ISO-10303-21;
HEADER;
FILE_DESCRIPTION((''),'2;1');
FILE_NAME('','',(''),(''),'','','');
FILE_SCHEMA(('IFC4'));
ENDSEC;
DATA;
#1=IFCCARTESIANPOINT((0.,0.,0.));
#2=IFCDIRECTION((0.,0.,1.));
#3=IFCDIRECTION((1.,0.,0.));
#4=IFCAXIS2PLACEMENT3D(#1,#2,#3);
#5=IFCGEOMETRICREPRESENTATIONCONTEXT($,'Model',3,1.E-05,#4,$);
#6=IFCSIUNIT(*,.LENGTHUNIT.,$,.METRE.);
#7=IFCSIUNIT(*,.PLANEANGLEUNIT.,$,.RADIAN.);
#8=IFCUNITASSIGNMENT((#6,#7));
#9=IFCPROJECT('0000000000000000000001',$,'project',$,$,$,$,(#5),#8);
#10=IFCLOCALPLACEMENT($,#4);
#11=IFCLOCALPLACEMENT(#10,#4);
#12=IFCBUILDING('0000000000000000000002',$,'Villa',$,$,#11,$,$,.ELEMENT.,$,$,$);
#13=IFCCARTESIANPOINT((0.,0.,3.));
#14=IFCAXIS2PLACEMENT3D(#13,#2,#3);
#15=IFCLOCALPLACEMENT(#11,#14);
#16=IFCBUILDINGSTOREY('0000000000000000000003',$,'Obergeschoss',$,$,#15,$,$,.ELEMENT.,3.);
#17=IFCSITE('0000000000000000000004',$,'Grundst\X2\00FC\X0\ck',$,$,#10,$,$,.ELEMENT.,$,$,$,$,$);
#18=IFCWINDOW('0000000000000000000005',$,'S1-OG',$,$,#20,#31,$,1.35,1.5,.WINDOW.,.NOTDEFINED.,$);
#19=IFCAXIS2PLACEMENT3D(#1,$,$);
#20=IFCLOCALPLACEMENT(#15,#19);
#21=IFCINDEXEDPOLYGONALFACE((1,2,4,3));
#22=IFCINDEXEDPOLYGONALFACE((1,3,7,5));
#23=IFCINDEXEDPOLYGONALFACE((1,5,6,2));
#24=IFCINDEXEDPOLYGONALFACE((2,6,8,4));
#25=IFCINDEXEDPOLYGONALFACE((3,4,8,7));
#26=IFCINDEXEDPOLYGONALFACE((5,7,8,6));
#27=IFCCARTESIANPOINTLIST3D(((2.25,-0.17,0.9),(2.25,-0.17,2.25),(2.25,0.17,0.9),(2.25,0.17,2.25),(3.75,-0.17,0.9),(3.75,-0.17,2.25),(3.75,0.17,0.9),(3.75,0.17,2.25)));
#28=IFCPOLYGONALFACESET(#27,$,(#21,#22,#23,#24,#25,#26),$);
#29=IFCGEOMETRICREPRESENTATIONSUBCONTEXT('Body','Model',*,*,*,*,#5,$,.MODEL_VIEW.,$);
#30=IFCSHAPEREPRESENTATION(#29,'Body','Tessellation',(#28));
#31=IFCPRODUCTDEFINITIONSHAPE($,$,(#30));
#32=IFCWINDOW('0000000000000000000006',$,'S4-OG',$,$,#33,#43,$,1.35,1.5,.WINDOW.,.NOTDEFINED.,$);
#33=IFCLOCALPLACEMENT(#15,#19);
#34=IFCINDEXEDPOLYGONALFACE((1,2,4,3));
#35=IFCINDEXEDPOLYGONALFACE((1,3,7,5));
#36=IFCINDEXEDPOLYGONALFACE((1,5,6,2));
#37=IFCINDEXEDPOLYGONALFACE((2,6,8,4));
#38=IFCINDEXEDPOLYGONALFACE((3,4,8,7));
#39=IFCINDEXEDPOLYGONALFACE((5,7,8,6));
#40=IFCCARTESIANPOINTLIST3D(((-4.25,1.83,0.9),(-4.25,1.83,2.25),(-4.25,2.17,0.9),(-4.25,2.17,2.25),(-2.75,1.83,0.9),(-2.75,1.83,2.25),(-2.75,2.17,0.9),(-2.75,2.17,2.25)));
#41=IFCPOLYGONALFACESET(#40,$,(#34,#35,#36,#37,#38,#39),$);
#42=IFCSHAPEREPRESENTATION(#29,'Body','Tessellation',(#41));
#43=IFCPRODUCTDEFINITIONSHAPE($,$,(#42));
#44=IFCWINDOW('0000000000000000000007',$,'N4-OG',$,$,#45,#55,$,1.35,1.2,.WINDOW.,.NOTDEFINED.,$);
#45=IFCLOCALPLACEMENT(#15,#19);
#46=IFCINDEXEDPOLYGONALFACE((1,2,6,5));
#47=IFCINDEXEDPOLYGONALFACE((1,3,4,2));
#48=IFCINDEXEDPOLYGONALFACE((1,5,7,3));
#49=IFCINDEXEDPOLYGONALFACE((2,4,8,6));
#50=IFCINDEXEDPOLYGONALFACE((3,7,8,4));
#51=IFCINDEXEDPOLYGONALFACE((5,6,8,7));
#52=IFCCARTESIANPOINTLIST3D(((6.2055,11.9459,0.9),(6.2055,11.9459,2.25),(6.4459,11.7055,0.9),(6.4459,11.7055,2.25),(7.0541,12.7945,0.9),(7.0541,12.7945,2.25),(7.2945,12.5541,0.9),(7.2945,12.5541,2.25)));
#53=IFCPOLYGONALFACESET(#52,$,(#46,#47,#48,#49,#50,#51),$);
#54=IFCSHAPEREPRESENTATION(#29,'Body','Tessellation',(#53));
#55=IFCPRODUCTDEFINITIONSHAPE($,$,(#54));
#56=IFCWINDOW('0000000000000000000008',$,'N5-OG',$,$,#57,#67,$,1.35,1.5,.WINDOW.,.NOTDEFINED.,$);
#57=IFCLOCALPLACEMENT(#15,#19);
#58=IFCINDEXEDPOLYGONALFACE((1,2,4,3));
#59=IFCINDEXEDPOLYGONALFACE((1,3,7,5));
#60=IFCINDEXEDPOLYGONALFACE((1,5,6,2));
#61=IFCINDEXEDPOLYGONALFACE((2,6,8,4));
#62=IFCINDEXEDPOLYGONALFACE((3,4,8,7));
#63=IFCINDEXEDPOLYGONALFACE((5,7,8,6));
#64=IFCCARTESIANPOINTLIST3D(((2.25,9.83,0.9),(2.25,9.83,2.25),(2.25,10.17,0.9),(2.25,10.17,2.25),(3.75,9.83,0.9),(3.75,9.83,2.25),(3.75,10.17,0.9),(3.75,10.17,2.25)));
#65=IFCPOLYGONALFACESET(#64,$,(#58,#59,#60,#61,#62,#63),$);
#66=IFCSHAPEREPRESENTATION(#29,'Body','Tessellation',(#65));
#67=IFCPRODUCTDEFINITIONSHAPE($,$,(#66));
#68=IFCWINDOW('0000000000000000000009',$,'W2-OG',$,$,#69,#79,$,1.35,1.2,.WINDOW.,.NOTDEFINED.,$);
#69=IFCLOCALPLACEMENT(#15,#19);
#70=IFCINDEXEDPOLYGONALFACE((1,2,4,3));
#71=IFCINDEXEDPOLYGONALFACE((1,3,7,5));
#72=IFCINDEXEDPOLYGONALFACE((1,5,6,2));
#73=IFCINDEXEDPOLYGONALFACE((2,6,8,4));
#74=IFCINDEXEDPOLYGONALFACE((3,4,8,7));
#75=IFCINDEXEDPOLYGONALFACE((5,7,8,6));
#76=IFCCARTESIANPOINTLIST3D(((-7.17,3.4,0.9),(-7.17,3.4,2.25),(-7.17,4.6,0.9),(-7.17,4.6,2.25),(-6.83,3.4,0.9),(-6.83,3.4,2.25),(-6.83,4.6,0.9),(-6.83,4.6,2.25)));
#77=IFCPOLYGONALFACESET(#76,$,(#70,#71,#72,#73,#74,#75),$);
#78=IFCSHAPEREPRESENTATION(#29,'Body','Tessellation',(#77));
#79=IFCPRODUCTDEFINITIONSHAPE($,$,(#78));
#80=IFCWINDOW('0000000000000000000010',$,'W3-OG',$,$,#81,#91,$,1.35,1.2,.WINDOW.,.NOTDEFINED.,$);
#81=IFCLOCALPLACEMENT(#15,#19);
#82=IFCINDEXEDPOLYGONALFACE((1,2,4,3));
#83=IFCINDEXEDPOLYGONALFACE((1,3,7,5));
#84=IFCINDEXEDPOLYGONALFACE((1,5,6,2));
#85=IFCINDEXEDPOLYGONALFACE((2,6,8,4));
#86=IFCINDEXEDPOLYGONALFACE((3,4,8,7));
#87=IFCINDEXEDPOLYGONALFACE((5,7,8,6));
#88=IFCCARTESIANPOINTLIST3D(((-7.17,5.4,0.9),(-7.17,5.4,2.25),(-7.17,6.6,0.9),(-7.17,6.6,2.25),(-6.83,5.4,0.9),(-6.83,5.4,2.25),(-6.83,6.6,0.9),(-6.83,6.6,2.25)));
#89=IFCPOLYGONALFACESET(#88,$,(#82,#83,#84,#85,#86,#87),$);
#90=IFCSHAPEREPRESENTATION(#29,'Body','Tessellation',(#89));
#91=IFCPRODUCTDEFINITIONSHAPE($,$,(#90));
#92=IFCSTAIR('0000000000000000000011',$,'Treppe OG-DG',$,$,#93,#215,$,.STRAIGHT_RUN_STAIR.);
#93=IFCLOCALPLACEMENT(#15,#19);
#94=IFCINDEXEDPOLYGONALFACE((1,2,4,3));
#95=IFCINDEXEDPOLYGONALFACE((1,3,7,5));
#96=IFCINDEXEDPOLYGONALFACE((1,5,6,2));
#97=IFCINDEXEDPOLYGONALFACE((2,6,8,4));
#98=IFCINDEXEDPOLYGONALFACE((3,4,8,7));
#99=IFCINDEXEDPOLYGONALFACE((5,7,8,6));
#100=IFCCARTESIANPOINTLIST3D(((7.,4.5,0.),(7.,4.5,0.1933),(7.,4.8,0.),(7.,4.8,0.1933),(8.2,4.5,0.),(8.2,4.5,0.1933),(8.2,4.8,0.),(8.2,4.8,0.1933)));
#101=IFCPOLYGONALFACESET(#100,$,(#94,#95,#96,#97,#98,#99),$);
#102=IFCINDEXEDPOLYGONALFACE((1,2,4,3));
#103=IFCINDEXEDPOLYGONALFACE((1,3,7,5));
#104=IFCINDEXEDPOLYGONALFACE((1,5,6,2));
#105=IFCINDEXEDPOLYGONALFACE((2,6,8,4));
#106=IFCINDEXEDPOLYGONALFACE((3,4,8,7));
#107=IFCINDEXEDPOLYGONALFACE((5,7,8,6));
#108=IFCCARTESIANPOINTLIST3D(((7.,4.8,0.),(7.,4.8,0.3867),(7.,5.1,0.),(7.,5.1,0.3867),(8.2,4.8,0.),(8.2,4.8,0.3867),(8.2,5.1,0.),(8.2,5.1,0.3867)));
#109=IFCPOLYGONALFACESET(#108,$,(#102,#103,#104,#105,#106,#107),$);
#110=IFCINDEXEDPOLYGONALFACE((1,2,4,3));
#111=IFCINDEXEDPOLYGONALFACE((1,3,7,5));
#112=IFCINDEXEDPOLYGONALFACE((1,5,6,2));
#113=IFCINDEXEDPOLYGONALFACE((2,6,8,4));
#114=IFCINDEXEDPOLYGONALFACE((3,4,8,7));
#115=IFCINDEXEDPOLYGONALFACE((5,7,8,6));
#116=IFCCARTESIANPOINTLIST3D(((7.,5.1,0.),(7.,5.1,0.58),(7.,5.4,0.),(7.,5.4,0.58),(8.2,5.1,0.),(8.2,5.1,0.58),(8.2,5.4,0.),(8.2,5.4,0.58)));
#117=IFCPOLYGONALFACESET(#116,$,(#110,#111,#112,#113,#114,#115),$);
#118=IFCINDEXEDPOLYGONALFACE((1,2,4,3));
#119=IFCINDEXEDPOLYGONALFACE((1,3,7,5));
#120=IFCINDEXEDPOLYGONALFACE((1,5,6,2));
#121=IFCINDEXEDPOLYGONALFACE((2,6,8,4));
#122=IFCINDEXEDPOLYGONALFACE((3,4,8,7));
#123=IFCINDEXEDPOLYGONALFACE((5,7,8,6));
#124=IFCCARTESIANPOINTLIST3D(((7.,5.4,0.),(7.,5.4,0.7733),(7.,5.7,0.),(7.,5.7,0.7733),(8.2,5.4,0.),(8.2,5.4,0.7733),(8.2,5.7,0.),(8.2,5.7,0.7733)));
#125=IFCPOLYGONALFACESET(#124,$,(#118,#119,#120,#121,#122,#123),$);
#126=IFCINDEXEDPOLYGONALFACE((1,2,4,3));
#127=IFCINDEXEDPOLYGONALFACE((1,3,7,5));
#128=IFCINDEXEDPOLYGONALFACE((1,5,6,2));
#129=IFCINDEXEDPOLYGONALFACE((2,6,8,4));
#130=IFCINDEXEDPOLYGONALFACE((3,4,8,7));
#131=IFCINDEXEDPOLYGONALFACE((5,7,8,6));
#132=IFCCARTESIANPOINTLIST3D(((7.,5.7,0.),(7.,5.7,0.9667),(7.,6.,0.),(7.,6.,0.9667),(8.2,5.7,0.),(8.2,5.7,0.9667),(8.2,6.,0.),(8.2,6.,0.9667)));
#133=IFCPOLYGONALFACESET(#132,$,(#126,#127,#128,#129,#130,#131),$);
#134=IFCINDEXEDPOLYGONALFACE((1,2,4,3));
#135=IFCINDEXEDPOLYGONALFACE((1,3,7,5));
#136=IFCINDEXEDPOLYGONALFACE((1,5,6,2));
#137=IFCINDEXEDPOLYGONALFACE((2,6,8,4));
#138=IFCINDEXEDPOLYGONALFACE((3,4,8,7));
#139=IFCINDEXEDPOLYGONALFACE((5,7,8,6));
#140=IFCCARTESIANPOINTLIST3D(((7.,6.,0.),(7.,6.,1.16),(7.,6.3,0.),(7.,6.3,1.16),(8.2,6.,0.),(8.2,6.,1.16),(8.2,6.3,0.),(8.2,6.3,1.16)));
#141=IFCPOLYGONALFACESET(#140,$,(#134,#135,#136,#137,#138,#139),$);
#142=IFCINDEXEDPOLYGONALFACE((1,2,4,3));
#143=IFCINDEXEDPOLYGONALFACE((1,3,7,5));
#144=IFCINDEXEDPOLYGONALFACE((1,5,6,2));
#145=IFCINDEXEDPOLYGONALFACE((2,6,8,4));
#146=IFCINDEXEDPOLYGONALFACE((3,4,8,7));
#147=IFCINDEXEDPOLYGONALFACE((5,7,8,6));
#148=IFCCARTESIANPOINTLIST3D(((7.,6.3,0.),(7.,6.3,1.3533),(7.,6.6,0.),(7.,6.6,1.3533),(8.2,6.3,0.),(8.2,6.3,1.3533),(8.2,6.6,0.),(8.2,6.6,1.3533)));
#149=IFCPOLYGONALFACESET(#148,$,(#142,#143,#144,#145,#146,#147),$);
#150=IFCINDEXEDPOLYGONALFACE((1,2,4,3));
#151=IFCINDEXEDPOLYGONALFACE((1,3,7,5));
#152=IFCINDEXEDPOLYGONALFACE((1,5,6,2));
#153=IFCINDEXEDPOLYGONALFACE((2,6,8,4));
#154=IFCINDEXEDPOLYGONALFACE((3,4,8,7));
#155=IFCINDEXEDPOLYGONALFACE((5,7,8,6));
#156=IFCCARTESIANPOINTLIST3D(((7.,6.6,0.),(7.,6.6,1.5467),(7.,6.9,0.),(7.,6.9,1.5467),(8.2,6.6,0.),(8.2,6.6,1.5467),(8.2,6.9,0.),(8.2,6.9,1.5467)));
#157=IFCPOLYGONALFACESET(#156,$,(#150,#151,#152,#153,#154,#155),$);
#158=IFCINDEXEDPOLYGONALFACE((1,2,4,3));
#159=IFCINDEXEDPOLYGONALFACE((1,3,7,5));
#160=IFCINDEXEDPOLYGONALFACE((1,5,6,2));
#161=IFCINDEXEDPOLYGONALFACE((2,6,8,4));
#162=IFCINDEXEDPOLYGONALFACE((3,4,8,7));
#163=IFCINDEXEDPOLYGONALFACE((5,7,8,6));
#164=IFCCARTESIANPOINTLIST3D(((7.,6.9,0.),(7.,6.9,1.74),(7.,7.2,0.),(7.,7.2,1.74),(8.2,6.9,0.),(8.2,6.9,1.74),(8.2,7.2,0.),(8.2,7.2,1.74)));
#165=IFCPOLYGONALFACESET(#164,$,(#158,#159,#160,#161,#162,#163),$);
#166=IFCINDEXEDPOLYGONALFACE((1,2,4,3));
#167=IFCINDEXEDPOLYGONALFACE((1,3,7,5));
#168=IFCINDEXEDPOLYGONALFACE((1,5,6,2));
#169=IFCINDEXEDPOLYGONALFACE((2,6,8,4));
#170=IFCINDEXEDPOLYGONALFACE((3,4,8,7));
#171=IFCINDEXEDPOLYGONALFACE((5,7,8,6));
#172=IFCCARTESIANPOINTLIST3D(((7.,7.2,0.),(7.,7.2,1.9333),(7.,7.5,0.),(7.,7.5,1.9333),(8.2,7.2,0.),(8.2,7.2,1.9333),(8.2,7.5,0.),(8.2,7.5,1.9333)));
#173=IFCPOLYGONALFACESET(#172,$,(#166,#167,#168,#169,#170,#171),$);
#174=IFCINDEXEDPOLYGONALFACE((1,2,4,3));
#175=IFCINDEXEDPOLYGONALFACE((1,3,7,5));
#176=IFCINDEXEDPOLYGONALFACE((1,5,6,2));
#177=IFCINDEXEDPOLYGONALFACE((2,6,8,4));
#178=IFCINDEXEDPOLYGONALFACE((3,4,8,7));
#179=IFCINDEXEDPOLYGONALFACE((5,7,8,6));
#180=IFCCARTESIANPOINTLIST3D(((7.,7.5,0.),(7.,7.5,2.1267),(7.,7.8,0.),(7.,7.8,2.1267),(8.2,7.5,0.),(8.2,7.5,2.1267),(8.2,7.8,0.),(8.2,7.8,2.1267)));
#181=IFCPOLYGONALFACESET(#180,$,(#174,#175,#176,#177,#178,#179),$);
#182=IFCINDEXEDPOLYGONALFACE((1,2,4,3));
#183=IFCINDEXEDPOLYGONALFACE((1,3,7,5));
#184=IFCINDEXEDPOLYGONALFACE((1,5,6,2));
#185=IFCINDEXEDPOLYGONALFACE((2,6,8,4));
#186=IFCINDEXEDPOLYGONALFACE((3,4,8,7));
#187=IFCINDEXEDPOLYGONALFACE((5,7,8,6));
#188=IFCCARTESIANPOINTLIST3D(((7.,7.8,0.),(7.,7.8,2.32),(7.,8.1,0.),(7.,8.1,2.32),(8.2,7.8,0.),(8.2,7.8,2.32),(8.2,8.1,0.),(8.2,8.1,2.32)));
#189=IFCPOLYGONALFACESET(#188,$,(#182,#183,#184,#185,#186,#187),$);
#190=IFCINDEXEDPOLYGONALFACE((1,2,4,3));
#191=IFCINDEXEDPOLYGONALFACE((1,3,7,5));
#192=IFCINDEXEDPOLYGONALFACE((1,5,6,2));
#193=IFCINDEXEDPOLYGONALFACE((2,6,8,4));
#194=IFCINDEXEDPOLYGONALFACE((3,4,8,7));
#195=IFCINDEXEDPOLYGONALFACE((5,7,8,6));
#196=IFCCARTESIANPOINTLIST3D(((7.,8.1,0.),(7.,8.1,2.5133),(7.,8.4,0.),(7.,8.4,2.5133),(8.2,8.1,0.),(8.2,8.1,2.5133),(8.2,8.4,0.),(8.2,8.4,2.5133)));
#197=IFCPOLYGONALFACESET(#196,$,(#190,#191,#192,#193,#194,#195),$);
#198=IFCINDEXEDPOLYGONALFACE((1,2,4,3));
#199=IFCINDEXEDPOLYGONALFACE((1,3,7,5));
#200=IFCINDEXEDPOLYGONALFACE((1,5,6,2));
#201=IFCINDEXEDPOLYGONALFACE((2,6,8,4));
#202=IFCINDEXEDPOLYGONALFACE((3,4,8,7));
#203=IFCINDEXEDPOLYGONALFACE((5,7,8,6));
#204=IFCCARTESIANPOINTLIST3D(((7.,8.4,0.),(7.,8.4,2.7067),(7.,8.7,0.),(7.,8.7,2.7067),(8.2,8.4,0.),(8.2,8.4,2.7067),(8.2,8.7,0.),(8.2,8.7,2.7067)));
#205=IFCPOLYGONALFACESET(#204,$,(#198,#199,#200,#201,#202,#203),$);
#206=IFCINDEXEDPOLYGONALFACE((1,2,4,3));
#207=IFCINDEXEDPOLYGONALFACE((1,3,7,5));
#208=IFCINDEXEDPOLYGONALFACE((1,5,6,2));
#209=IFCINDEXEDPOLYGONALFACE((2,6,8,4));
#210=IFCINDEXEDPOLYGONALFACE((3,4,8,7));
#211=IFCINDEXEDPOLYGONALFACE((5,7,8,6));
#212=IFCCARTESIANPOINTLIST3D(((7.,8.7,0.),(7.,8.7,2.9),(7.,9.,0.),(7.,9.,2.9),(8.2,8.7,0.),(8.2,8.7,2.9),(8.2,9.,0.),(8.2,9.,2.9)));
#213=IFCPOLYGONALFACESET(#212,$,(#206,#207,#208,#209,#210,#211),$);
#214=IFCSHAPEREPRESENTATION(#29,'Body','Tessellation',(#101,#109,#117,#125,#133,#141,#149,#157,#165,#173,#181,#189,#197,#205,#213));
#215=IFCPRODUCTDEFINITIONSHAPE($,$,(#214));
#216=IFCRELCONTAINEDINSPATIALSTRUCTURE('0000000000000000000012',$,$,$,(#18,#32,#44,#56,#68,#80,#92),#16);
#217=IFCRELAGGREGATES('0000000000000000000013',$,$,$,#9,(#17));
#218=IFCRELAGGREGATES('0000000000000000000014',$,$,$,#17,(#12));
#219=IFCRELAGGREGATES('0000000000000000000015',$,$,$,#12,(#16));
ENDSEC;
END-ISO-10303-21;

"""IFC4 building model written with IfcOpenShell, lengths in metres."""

from ifc_helpers import new_model, si_unit, frame, frame_2d, origin_with_axes, origin_2d, place, context, subcontext, project, spatial, rectangle, extrude, element, save


model = new_model("IFC4")

# Units and contexts
model_context = context("Model", 3, precision=1e-05, world=origin_with_axes())
body_context = subcontext(model_context, "Body", "Model", "MODEL_VIEW")
ifc_project = project(units=[si_unit("LENGTHUNIT", "METRE"), si_unit("PLANEANGLEUNIT", "RADIAN")], contexts=[model_context])

# Site, building, storey
site_placement = place(None, origin_with_axes())
site = spatial("IfcSite", under=ifc_project, at=site_placement, Name="Grundstück", CompositionType="ELEMENT")
building_placement = place(site_placement, origin_with_axes())
building = spatial("IfcBuilding", under=site, at=building_placement, Name="Villa", CompositionType="ELEMENT")
storey_placement = place(building_placement, frame((0.0, 0.0, 3.0), z_axis=(0.0, 0.0, 1.0), x_axis=(1.0, 0.0, 0.0)))
storey = spatial("IfcBuildingStorey", under=building, at=storey_placement, Name="Obergeschoss", CompositionType="ELEMENT", Elevation=3.0)

# Windows
for number, where, z_axis, x_axis, name in (
    (1, (3.0, 0.0, 0.9), (0.0, 0.0, 1.0), (1.0, 0.0, 0.0), "S1-OG"),
    (2, (-3.5, 2.0, 0.9), (0.0, 0.0, 1.0), (1.0, 0.0, 0.0), "S4-OG"),
):
    element("IfcWindow", number, at=place(storey_placement, frame(where, z_axis=z_axis, x_axis=x_axis)), inside=storey, Name=name, OverallHeight=1.35, OverallWidth=1.5, PartitioningType="NOTDEFINED", PredefinedType="WINDOW", context=body_context, shape_type="SweptSolid", body=[
        extrude(rectangle(XDim=1.5, YDim=0.34, at=origin_2d()), origin_with_axes(), (0.0, 0.0, 1.0), 1.35),
    ])
window_1_placement = place(storey_placement, frame((6.75, 12.25, 0.9), z_axis=(0.0, 0.0, 1.0), x_axis=(-0.7071, -0.7071, 0.0)))
element("IfcWindow", 3, at=window_1_placement, inside=storey, Name="N4-OG", OverallHeight=1.35, OverallWidth=1.2, PartitioningType="NOTDEFINED", PredefinedType="WINDOW", context=body_context, shape_type="SweptSolid", body=[
    extrude(rectangle(XDim=1.2, YDim=0.34, at=origin_2d()), origin_with_axes(), (0.0, 0.0, 1.0), 1.35),
])
window_2_placement = place(storey_placement, frame((3.0, 10.0, 0.9), z_axis=(0.0, 0.0, 1.0), x_axis=(1.0, 0.0, 0.0)))
element("IfcWindow", 4, at=window_2_placement, inside=storey, Name="N5-OG", OverallHeight=1.35, OverallWidth=1.5, PartitioningType="NOTDEFINED", PredefinedType="WINDOW", context=body_context, shape_type="SweptSolid", body=[
    extrude(rectangle(XDim=1.5, YDim=0.34, at=origin_2d()), origin_with_axes(), (0.0, 0.0, 1.0), 1.35),
])
for number, where, z_axis, x_axis, name in (
    (5, (-7.0, 4.0, 0.9), (0.0, 0.0, 1.0), (0.0, 1.0, 0.0), "W2-OG"),
    (6, (-7.0, 6.0, 0.9), (0.0, 0.0, 1.0), (0.0, 1.0, 0.0), "W3-OG"),
):
    element("IfcWindow", number, at=place(storey_placement, frame(where, z_axis=z_axis, x_axis=x_axis)), inside=storey, Name=name, OverallHeight=1.35, OverallWidth=1.2, PartitioningType="NOTDEFINED", PredefinedType="WINDOW", context=body_context, shape_type="SweptSolid", body=[
        extrude(rectangle(XDim=1.2, YDim=0.34, at=origin_2d()), origin_with_axes(), (0.0, 0.0, 1.0), 1.35),
    ])

# Stair
stair_placement = place(storey_placement, origin_with_axes())
element("IfcStair", 7, at=stair_placement, inside=storey, Name="Treppe OG-DG", PredefinedType="STRAIGHT_RUN_STAIR", context=body_context, shape_type="SweptSolid", body=[
    extrude(rectangle(XDim=1.2, YDim=0.3, at=frame_2d((7.6, 4.65))), origin_with_axes(), (0.0, 0.0, 1.0), 0.1933),
    extrude(rectangle(XDim=1.2, YDim=0.3, at=frame_2d((7.6, 4.95))), origin_with_axes(), (0.0, 0.0, 1.0), 0.3867),
    extrude(rectangle(XDim=1.2, YDim=0.3, at=frame_2d((7.6, 5.25))), origin_with_axes(), (0.0, 0.0, 1.0), 0.58),
    extrude(rectangle(XDim=1.2, YDim=0.3, at=frame_2d((7.6, 5.55))), origin_with_axes(), (0.0, 0.0, 1.0), 0.7733),
    extrude(rectangle(XDim=1.2, YDim=0.3, at=frame_2d((7.6, 5.85))), origin_with_axes(), (0.0, 0.0, 1.0), 0.9667),
    extrude(rectangle(XDim=1.2, YDim=0.3, at=frame_2d((7.6, 6.15))), origin_with_axes(), (0.0, 0.0, 1.0), 1.16),
    extrude(rectangle(XDim=1.2, YDim=0.3, at=frame_2d((7.6, 6.45))), origin_with_axes(), (0.0, 0.0, 1.0), 1.3533),
    extrude(rectangle(XDim=1.2, YDim=0.3, at=frame_2d((7.6, 6.75))), origin_with_axes(), (0.0, 0.0, 1.0), 1.5467),
    extrude(rectangle(XDim=1.2, YDim=0.3, at=frame_2d((7.6, 7.05))), origin_with_axes(), (0.0, 0.0, 1.0), 1.74),
    extrude(rectangle(XDim=1.2, YDim=0.3, at=frame_2d((7.6, 7.35))), origin_with_axes(), (0.0, 0.0, 1.0), 1.9333),
    extrude(rectangle(XDim=1.2, YDim=0.3, at=frame_2d((7.6, 7.65))), origin_with_axes(), (0.0, 0.0, 1.0), 2.1267),
    extrude(rectangle(XDim=1.2, YDim=0.3, at=frame_2d((7.6, 7.95))), origin_with_axes(), (0.0, 0.0, 1.0), 2.32),
    extrude(rectangle(XDim=1.2, YDim=0.3, at=frame_2d((7.6, 8.25))), origin_with_axes(), (0.0, 0.0, 1.0), 2.5133),
    extrude(rectangle(XDim=1.2, YDim=0.3, at=frame_2d((7.6, 8.55))), origin_with_axes(), (0.0, 0.0, 1.0), 2.7067),
    extrude(rectangle(XDim=1.2, YDim=0.3, at=frame_2d((7.6, 8.85))), origin_with_axes(), (0.0, 0.0, 1.0), 2.9),
])

save(model, "model.ifc")
